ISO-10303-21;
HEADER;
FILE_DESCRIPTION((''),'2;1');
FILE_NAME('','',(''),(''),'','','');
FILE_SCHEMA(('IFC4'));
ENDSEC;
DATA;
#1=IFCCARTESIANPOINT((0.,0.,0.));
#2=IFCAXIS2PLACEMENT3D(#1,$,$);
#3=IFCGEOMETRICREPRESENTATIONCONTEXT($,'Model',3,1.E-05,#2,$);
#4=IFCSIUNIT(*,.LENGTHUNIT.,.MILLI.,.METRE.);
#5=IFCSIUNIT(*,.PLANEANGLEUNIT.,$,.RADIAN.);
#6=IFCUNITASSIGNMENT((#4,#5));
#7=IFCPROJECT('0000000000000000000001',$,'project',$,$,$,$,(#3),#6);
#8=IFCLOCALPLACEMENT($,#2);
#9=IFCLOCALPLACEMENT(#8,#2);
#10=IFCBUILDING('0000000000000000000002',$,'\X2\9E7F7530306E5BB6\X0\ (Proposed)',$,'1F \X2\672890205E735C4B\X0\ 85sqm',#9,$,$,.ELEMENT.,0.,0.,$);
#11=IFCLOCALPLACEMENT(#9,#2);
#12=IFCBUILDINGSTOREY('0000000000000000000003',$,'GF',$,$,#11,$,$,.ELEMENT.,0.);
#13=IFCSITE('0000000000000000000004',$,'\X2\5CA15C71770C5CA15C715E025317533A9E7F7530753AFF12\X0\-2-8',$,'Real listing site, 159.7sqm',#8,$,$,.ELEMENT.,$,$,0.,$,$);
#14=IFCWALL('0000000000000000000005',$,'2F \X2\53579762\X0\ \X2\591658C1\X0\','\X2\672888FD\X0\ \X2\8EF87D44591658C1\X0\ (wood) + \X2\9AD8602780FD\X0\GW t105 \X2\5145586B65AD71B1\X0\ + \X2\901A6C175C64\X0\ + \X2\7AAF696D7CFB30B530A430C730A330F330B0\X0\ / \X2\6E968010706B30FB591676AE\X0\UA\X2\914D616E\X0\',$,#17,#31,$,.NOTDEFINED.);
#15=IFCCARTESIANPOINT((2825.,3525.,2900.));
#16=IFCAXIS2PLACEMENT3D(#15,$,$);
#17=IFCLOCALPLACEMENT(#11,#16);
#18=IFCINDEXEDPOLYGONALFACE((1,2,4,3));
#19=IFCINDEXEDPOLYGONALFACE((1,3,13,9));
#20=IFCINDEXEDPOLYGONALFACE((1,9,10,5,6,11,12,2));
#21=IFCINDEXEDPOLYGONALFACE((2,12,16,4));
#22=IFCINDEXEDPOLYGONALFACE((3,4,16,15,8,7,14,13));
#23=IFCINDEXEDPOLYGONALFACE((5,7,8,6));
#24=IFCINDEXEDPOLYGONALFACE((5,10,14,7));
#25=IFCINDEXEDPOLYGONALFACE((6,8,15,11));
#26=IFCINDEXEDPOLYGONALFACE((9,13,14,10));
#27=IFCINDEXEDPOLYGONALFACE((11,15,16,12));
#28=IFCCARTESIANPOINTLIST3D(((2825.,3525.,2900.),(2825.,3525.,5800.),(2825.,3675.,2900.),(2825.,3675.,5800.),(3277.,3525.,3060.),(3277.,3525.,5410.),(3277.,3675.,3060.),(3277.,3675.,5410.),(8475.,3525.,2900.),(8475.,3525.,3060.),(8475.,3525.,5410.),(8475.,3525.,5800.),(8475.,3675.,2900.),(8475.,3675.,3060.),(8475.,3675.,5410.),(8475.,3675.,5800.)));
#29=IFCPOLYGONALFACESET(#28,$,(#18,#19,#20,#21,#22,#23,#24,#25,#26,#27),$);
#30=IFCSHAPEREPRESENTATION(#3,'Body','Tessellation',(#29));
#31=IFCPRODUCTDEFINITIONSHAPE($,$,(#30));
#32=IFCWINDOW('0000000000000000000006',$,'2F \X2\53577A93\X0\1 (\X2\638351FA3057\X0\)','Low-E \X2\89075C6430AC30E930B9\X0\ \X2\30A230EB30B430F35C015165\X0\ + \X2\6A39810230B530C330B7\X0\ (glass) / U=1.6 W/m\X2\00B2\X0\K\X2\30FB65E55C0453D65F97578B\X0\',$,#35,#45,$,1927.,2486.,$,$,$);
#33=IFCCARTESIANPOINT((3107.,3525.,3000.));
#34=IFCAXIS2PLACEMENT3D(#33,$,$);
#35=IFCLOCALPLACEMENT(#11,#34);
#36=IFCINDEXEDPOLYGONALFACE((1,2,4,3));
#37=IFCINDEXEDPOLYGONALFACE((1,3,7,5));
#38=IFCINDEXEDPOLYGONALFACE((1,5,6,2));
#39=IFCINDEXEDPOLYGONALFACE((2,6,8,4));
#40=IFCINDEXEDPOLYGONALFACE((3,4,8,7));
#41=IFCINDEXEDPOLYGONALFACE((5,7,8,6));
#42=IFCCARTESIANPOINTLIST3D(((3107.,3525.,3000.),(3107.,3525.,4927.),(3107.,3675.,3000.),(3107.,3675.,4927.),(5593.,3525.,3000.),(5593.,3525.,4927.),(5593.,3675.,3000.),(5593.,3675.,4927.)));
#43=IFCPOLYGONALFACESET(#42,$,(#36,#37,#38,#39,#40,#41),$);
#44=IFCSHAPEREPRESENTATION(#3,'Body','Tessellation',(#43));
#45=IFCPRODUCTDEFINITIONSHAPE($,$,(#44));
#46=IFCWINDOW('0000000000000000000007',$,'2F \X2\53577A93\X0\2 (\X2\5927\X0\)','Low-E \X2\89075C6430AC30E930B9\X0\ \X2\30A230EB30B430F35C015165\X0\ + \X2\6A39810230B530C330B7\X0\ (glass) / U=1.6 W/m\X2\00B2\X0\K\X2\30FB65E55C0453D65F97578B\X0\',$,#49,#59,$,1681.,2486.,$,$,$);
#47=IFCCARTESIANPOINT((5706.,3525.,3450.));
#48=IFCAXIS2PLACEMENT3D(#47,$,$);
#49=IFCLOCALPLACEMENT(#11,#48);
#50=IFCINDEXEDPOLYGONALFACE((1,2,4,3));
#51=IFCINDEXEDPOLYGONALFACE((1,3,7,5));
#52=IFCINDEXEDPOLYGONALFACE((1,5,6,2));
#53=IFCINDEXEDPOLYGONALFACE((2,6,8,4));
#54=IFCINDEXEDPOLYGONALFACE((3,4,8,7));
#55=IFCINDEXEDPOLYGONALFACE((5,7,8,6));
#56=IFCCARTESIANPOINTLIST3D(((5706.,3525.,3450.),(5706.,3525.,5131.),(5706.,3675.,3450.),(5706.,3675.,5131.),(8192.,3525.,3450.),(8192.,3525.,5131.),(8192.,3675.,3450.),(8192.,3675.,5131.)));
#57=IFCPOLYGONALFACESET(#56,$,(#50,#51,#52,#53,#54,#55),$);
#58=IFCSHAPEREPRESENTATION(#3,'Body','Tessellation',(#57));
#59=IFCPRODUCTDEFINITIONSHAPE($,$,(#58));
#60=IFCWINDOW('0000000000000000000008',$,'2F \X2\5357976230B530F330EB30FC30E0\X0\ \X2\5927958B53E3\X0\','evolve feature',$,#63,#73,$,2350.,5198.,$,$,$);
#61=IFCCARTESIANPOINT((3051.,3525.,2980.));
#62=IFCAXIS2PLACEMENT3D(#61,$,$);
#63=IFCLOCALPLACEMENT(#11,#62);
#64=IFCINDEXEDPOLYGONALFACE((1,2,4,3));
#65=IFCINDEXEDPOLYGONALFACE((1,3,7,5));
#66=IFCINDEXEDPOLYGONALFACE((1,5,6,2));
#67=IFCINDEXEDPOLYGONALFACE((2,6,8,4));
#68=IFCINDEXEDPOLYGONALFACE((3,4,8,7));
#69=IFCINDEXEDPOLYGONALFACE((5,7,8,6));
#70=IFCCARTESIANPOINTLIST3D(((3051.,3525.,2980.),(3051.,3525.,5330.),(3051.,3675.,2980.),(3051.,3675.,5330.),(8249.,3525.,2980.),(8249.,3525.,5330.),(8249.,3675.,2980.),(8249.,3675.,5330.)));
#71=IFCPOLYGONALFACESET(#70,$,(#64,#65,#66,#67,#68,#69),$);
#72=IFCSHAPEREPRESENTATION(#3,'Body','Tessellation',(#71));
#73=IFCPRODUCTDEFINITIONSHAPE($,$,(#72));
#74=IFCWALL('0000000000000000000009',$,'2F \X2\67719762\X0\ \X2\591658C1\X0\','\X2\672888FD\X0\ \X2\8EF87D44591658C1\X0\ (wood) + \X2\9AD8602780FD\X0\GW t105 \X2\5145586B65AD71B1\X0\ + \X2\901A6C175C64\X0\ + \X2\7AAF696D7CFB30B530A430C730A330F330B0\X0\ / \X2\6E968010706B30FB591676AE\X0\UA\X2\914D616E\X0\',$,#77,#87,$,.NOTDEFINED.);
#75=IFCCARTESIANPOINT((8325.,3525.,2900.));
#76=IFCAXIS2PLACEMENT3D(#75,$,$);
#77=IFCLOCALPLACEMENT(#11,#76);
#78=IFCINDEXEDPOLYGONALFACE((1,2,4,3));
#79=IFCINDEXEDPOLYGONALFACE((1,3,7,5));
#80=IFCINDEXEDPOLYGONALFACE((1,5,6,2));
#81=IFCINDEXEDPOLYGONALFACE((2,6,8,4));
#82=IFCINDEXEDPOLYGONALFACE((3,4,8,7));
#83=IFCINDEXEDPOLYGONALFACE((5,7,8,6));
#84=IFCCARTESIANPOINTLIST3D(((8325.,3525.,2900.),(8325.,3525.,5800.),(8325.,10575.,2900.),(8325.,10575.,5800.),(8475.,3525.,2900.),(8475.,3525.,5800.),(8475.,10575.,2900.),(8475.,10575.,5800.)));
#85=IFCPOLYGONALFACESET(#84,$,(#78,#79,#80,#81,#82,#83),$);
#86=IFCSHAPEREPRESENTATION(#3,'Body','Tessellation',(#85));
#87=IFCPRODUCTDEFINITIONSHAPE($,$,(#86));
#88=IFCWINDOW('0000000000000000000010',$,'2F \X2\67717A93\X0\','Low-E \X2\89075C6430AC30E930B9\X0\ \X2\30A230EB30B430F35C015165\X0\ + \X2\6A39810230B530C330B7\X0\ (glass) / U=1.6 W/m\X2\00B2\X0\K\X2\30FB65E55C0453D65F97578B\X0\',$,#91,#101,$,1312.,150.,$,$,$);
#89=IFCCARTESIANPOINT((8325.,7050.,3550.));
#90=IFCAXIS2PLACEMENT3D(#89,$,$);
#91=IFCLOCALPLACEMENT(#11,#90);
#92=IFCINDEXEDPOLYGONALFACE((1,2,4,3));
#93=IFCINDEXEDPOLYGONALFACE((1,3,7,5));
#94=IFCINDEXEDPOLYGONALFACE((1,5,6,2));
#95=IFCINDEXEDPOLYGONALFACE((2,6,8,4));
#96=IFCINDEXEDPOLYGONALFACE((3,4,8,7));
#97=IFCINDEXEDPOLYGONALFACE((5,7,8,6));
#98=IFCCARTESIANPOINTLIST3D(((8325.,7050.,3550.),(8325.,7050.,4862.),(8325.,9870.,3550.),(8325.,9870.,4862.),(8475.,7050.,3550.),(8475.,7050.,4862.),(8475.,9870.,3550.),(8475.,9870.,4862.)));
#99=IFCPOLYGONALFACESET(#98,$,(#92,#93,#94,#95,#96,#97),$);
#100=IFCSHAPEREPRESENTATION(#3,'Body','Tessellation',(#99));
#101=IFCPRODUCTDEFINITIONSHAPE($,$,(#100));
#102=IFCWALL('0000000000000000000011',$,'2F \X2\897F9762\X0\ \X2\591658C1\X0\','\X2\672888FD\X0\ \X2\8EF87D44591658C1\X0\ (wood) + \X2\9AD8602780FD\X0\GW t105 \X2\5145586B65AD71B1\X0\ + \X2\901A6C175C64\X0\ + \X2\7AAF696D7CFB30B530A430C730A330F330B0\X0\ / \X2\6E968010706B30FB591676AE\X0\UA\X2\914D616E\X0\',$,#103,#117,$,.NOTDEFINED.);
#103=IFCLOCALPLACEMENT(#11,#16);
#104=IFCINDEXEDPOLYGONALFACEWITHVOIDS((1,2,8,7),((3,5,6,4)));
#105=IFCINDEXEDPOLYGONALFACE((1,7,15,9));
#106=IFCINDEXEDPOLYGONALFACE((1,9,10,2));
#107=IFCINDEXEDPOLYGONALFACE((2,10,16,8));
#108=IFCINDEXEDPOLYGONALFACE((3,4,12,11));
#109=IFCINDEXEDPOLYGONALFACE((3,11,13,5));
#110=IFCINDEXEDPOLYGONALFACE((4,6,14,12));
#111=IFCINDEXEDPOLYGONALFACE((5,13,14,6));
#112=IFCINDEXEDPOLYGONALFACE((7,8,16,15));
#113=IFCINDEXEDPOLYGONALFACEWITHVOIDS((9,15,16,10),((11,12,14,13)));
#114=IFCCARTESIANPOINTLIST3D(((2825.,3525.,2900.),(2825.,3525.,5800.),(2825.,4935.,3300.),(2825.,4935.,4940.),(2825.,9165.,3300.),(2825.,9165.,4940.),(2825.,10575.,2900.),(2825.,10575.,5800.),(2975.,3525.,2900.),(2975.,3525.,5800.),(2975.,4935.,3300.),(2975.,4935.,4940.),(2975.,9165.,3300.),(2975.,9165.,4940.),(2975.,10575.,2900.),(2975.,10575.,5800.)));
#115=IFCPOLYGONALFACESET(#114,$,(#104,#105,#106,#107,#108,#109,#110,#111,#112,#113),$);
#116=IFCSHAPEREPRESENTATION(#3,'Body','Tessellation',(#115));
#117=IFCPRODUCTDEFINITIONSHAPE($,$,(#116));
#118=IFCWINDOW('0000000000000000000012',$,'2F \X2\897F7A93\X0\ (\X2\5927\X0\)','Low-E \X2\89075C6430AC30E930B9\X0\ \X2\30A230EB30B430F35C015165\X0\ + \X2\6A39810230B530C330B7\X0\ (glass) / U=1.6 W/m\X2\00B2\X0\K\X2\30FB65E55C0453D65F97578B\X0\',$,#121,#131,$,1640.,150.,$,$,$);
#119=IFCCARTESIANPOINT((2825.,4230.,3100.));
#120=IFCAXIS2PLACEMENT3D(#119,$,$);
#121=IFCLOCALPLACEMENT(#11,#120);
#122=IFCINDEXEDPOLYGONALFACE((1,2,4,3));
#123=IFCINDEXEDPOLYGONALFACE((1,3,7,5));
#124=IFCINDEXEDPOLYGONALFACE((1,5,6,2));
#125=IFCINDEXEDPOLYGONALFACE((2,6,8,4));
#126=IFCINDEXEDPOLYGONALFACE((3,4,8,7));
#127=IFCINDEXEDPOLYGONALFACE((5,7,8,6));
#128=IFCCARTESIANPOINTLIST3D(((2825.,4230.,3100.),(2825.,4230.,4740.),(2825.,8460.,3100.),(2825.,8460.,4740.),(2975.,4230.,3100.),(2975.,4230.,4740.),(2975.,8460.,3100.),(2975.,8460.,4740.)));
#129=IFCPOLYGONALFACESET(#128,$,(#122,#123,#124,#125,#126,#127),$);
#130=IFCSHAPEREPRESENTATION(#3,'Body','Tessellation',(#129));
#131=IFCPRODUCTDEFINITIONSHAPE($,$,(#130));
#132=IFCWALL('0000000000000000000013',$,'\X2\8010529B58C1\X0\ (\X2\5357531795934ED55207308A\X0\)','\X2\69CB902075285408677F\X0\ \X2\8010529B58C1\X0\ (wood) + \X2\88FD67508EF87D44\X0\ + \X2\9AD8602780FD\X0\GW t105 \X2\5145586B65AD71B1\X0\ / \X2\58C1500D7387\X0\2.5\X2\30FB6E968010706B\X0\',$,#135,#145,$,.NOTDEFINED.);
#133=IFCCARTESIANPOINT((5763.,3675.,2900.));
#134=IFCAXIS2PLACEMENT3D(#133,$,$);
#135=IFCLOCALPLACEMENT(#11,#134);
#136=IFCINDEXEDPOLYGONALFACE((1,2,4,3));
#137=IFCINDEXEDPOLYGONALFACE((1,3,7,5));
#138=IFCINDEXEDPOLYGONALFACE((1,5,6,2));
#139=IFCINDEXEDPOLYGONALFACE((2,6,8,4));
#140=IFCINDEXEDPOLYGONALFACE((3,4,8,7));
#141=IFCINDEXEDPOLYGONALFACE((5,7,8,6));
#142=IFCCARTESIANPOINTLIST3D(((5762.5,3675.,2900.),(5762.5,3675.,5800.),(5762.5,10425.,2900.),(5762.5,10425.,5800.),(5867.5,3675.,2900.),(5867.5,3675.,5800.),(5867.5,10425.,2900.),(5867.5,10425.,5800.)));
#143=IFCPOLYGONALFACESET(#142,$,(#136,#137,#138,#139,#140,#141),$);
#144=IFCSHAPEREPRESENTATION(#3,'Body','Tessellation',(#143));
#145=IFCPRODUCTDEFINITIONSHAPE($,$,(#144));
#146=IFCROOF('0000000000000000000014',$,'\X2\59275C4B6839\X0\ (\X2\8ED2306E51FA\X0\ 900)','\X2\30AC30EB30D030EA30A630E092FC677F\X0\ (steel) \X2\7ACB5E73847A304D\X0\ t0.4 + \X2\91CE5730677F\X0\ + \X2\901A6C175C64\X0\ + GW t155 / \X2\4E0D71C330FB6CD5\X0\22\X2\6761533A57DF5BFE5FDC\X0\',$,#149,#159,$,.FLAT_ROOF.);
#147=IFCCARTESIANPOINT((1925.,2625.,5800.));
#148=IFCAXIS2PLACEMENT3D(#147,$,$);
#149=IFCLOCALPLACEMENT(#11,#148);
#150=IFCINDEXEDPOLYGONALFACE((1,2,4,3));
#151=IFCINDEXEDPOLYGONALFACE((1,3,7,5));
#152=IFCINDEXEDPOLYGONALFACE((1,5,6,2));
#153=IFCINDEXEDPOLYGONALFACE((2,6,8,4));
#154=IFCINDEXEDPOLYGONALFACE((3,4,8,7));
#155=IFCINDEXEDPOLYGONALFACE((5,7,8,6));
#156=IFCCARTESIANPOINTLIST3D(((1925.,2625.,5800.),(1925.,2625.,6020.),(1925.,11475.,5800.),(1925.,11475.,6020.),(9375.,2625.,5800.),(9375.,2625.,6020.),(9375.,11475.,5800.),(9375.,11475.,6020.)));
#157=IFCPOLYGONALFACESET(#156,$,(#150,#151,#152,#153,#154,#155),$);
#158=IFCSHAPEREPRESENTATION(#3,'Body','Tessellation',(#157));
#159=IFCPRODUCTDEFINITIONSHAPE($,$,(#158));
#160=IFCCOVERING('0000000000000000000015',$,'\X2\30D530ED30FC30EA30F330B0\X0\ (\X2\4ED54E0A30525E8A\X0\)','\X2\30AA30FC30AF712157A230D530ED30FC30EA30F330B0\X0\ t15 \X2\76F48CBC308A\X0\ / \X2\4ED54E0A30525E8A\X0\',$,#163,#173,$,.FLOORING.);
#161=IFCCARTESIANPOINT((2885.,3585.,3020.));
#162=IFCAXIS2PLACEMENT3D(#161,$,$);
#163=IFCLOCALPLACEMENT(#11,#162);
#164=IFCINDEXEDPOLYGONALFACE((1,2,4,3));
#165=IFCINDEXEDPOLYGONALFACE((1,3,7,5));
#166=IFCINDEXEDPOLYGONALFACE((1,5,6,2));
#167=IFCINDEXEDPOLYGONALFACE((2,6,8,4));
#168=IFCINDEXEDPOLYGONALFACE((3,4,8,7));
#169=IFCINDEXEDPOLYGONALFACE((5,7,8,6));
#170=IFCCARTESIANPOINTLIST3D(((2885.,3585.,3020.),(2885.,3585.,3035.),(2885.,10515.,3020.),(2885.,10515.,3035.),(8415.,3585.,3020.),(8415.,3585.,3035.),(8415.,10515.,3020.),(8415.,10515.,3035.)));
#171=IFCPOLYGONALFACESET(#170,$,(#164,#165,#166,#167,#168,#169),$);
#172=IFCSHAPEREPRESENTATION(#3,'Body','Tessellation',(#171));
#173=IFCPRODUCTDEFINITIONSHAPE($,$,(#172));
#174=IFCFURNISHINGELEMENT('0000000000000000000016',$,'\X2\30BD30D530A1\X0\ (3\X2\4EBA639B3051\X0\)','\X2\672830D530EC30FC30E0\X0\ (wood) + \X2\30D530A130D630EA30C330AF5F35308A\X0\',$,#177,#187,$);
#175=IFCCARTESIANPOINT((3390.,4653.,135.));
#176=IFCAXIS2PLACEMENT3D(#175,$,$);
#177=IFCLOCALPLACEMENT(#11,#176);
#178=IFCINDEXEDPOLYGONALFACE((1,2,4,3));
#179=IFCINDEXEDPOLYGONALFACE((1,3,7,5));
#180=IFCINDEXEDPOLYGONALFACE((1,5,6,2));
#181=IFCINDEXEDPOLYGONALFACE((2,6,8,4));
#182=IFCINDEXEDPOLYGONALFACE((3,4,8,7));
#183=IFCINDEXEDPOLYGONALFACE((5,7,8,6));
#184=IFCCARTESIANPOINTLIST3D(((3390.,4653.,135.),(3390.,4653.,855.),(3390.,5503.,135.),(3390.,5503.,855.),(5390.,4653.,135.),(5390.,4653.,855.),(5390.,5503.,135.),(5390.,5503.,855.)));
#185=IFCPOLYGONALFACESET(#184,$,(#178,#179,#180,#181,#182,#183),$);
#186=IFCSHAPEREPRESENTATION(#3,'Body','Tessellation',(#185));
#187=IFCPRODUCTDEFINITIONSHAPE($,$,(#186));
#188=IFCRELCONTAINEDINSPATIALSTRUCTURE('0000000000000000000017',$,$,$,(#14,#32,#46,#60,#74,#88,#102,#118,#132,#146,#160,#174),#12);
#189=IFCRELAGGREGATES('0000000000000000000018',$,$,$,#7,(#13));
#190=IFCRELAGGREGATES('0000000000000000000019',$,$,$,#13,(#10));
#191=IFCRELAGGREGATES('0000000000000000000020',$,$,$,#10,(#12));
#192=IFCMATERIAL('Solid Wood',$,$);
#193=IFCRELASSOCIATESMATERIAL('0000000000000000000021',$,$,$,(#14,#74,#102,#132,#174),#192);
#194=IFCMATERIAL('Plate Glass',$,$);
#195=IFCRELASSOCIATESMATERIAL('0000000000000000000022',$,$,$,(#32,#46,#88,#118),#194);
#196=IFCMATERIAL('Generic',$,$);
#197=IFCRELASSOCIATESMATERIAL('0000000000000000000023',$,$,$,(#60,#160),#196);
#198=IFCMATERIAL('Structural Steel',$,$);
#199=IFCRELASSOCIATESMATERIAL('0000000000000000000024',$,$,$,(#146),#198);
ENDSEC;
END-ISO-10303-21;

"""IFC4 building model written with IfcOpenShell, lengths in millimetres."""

from ifc_helpers import new_model, si_unit, frame, frame_2d, origin, place, context, project, spatial, rectangle, extrude, material, element, fill, save


model = new_model("IFC4")

# Units and contexts
model_context = context("Model", 3, precision=1e-05, world=origin())
ifc_project = project(units=[si_unit("LENGTHUNIT", "METRE", prefix="MILLI"), si_unit("PLANEANGLEUNIT", "RADIAN")], contexts=[model_context])

# Site, building, storey
site_placement = place(None, origin())
site = spatial("IfcSite", under=ifc_project, at=site_placement, Name="岡山県岡山市北区鹿田町２-2-8", ObjectType="Real listing site, 159.7sqm", CompositionType="ELEMENT", RefElevation=0.0)
building_placement = place(site_placement, origin())
building = spatial("IfcBuilding", under=site, at=building_placement, Name="鹿田の家 (Proposed)", ObjectType="1F 木造平屋 85sqm", CompositionType="ELEMENT", ElevationOfRefHeight=0.0, ElevationOfTerrain=0.0)
storey_placement = place(building_placement, origin())
storey = spatial("IfcBuildingStorey", under=building, at=storey_placement, Name="GF", CompositionType="ELEMENT", Elevation=0.0)

# Shared definitions
ifc_material_1 = material(Name="Solid Wood")

# Wall, openings, windows
wall_1_placement = place(storey_placement, frame((2825.0, 3525.0, 2900.0)))
wall_1 = element("IfcWall", 1, at=wall_1_placement, inside=storey, material=ifc_material_1, Name="2F 南面 外壁", Description="木製 軸組外壁 (wood) + 高性能GW t105 充填断熱 + 通気層 + 窯業系サイディング / 準耐火・外皮UA配慮", PredefinedType="NOTDEFINED", context=model_context, shape_type="SweptSolid", body=[
    extrude(rectangle(XDim=5650.0, YDim=150.0, at=frame_2d((2825.0, 75.0))), frame((2825.0, 3525.0, 2900.0)), (0.0, 0.0, 1.0), 2900.0),
])
opening_1_placement = place(storey_placement, frame((3107.0, 3525.0, 3000.0)))
opening_1 = element("IfcOpeningElement", 2, at=opening_1_placement, cuts=wall_1, PredefinedType="NOTDEFINED", context=model_context, shape_type="SweptSolid", body=[
    extrude(rectangle(XDim=2486.0, YDim=150.0, at=frame_2d((1243.0, 75.0))), frame((3107.0, 3525.0, 3000.0)), (0.0, 0.0, 1.0), 1927.0),
])
opening_2_placement = place(storey_placement, frame((5706.0, 3525.0, 3450.0)))
opening_2 = element("IfcOpeningElement", 3, at=opening_2_placement, cuts=wall_1, PredefinedType="NOTDEFINED", context=model_context, shape_type="SweptSolid", body=[
    extrude(rectangle(XDim=2486.0, YDim=150.0, at=frame_2d((1243.0, 75.0))), frame((5706.0, 3525.0, 3450.0)), (0.0, 0.0, 1.0), 1681.0),
])
opening_3_placement = place(storey_placement, frame((3051.0, 3525.0, 2980.0)))
opening_3 = element("IfcOpeningElement", 4, at=opening_3_placement, cuts=wall_1, PredefinedType="NOTDEFINED", context=model_context, shape_type="SweptSolid", body=[
    extrude(rectangle(XDim=5198.0, YDim=150.0, at=frame_2d((2599.0, 75.0))), frame((3051.0, 3525.0, 2980.0)), (0.0, 0.0, 1.0), 2350.0),
])
ifc_material_2 = material(Name="Plate Glass")
window_1_placement = place(storey_placement, frame((3107.0, 3525.0, 3000.0)))
window_1 = element("IfcWindow", 5, at=window_1_placement, inside=storey, material=ifc_material_2, Name="2F 南窓1 (掃出し)", Description="Low-E 複層ガラス アルゴン封入 + 樹脂サッシ (glass) / U=1.6 W/m²K・日射取得型", OverallHeight=1927.0, OverallWidth=2486.0, context=model_context, shape_type="SweptSolid", body=[
    extrude(rectangle(XDim=2486.0, YDim=150.0, at=frame_2d((1243.0, 75.0))), frame((3107.0, 3525.0, 3000.0)), (0.0, 0.0, 1.0), 1927.0),
])
fill(opening_1, window_1)
window_2_placement = place(storey_placement, frame((5706.0, 3525.0, 3450.0)))
window_2 = element("IfcWindow", 6, at=window_2_placement, inside=storey, material=ifc_material_2, Name="2F 南窓2 (大)", Description="Low-E 複層ガラス アルゴン封入 + 樹脂サッシ (glass) / U=1.6 W/m²K・日射取得型", OverallHeight=1681.0, OverallWidth=2486.0, context=model_context, shape_type="SweptSolid", body=[
    extrude(rectangle(XDim=2486.0, YDim=150.0, at=frame_2d((1243.0, 75.0))), frame((5706.0, 3525.0, 3450.0)), (0.0, 0.0, 1.0), 1681.0),
])
fill(opening_2, window_2)
ifc_material_3 = material(Name="Generic")
window_3_placement = place(storey_placement, frame((3051.0, 3525.0, 2980.0)))
window_3 = element("IfcWindow", 7, at=window_3_placement, inside=storey, material=ifc_material_3, Name="2F 南面サンルーム 大開口", Description="evolve feature", OverallHeight=2350.0, OverallWidth=5198.0, context=model_context, shape_type="SweptSolid", body=[
    extrude(rectangle(XDim=5198.0, YDim=150.0, at=frame_2d((2599.0, 75.0))), frame((3051.0, 3525.0, 2980.0)), (0.0, 0.0, 1.0), 2350.0),
])
fill(opening_3, window_3)

# Walls, openings, windows
wall_2_placement = place(storey_placement, frame((8325.0, 3525.0, 2900.0)))
wall_2 = element("IfcWall", 8, at=wall_2_placement, inside=storey, material=ifc_material_1, Name="2F 東面 外壁", Description="木製 軸組外壁 (wood) + 高性能GW t105 充填断熱 + 通気層 + 窯業系サイディング / 準耐火・外皮UA配慮", PredefinedType="NOTDEFINED", context=model_context, shape_type="SweptSolid", body=[
    extrude(rectangle(XDim=150.0, YDim=7050.0, at=frame_2d((75.0, 3525.0))), frame((8325.0, 3525.0, 2900.0)), (0.0, 0.0, 1.0), 2900.0),
])
opening_4_placement = place(storey_placement, frame((8325.0, 7050.0, 3550.0)))
opening_4 = element("IfcOpeningElement", 9, at=opening_4_placement, cuts=wall_2, PredefinedType="NOTDEFINED", context=model_context, shape_type="SweptSolid", body=[
    extrude(rectangle(XDim=150.0, YDim=2820.0, at=frame_2d((75.0, 1410.0))), frame((8325.0, 7050.0, 3550.0)), (0.0, 0.0, 1.0), 1312.0),
])
window_4_placement = place(storey_placement, frame((8325.0, 7050.0, 3550.0)))
window_4 = element("IfcWindow", 10, at=window_4_placement, inside=storey, material=ifc_material_2, Name="2F 東窓", Description="Low-E 複層ガラス アルゴン封入 + 樹脂サッシ (glass) / U=1.6 W/m²K・日射取得型", OverallHeight=1312.0, OverallWidth=150.0, context=model_context, shape_type="SweptSolid", body=[
    extrude(rectangle(XDim=150.0, YDim=2820.0, at=frame_2d((75.0, 1410.0))), frame((8325.0, 7050.0, 3550.0)), (0.0, 0.0, 1.0), 1312.0),
])
fill(opening_4, window_4)
wall_3_placement = place(storey_placement, frame((2825.0, 3525.0, 2900.0)))
wall_3 = element("IfcWall", 11, at=wall_3_placement, inside=storey, material=ifc_material_1, Name="2F 西面 外壁", Description="木製 軸組外壁 (wood) + 高性能GW t105 充填断熱 + 通気層 + 窯業系サイディング / 準耐火・外皮UA配慮", PredefinedType="NOTDEFINED", context=model_context, shape_type="SweptSolid", body=[
    extrude(rectangle(XDim=150.0, YDim=7050.0, at=frame_2d((75.0, 3525.0))), frame((2825.0, 3525.0, 2900.0)), (0.0, 0.0, 1.0), 2900.0),
])
opening_5_placement = place(storey_placement, frame((2825.0, 4230.0, 3100.0)))
opening_5 = element("IfcOpeningElement", 12, at=opening_5_placement, cuts=wall_3, PredefinedType="NOTDEFINED", context=model_context, shape_type="SweptSolid", body=[
    extrude(rectangle(XDim=150.0, YDim=4230.0, at=frame_2d((75.0, 2115.0))), frame((2825.0, 4230.0, 3100.0)), (0.0, 0.0, 1.0), 1640.0),
])
window_5_placement = place(storey_placement, frame((2825.0, 4230.0, 3100.0)))
window_5 = element("IfcWindow", 13, at=window_5_placement, inside=storey, material=ifc_material_2, Name="2F 西窓 (大)", Description="Low-E 複層ガラス アルゴン封入 + 樹脂サッシ (glass) / U=1.6 W/m²K・日射取得型", OverallHeight=1640.0, OverallWidth=150.0, context=model_context, shape_type="SweptSolid", body=[
    extrude(rectangle(XDim=150.0, YDim=4230.0, at=frame_2d((75.0, 2115.0))), frame((2825.0, 4230.0, 3100.0)), (0.0, 0.0, 1.0), 1640.0),
])
fill(opening_5, window_5)

# Wall
wall_4_placement = place(storey_placement, frame((5763.0, 3675.0, 2900.0)))
element("IfcWall", 14, at=wall_4_placement, inside=storey, material=ifc_material_1, Name="耐力壁 (南北間仕切り)", Description="構造用合板 耐力壁 (wood) + 製材軸組 + 高性能GW t105 充填断熱 / 壁倍率2.5・準耐火", PredefinedType="NOTDEFINED", context=model_context, shape_type="SweptSolid", body=[
    extrude(rectangle(XDim=105.0, YDim=6750.0, at=frame_2d((52.0, 3375.0))), frame((5763.0, 3675.0, 2900.0)), (0.0, 0.0, 1.0), 2900.0),
])

# Roof
ifc_material_4 = material(Name="Structural Steel")
roof_placement = place(storey_placement, frame((1925.0, 2625.0, 5800.0)))
element("IfcRoof", 15, at=roof_placement, inside=storey, material=ifc_material_4, Name="大屋根 (軒の出 900)", Description="ガルバリウム鋼板 (steel) 立平葺き t0.4 + 野地板 + 通気層 + GW t155 / 不燃・法22条区域対応", PredefinedType="FLAT_ROOF", context=model_context, shape_type="SweptSolid", body=[
    extrude(rectangle(XDim=7450.0, YDim=8850.0, at=frame_2d((3725.0, 4425.0))), frame((1925.0, 2625.0, 5800.0)), (0.0, 0.0, 1.0), 220.0),
])

# Covering
covering_placement = place(storey_placement, frame((2885.0, 3585.0, 3020.0)))
element("IfcCovering", 16, at=covering_placement, inside=storey, material=ifc_material_3, Name="フローリング (仕上げ床)", Description="オーク無垢フローリング t15 直貼り / 仕上げ床", PredefinedType="FLOORING", context=model_context, shape_type="SweptSolid", body=[
    extrude(rectangle(XDim=5530.0, YDim=6930.0, at=frame_2d((2765.0, 3465.0))), frame((2885.0, 3585.0, 3020.0)), (0.0, 0.0, 1.0), 15.0),
])

# Furnishing element
furnishing_1_placement = place(storey_placement, frame((3390.0, 4653.0, 135.0)))
element("IfcFurnishingElement", 17, at=furnishing_1_placement, inside=storey, material=ifc_material_1, Name="ソファ (3人掛け)", Description="木フレーム (wood) + ファブリック張り", context=model_context, shape_type="SweptSolid", body=[
    extrude(rectangle(XDim=2000.0, YDim=850.0, at=frame_2d((1000.0, 425.0))), frame((3390.0, 4653.0, 135.0)), (0.0, 0.0, 1.0), 720.0),
])

save(model, "model.ifc")
